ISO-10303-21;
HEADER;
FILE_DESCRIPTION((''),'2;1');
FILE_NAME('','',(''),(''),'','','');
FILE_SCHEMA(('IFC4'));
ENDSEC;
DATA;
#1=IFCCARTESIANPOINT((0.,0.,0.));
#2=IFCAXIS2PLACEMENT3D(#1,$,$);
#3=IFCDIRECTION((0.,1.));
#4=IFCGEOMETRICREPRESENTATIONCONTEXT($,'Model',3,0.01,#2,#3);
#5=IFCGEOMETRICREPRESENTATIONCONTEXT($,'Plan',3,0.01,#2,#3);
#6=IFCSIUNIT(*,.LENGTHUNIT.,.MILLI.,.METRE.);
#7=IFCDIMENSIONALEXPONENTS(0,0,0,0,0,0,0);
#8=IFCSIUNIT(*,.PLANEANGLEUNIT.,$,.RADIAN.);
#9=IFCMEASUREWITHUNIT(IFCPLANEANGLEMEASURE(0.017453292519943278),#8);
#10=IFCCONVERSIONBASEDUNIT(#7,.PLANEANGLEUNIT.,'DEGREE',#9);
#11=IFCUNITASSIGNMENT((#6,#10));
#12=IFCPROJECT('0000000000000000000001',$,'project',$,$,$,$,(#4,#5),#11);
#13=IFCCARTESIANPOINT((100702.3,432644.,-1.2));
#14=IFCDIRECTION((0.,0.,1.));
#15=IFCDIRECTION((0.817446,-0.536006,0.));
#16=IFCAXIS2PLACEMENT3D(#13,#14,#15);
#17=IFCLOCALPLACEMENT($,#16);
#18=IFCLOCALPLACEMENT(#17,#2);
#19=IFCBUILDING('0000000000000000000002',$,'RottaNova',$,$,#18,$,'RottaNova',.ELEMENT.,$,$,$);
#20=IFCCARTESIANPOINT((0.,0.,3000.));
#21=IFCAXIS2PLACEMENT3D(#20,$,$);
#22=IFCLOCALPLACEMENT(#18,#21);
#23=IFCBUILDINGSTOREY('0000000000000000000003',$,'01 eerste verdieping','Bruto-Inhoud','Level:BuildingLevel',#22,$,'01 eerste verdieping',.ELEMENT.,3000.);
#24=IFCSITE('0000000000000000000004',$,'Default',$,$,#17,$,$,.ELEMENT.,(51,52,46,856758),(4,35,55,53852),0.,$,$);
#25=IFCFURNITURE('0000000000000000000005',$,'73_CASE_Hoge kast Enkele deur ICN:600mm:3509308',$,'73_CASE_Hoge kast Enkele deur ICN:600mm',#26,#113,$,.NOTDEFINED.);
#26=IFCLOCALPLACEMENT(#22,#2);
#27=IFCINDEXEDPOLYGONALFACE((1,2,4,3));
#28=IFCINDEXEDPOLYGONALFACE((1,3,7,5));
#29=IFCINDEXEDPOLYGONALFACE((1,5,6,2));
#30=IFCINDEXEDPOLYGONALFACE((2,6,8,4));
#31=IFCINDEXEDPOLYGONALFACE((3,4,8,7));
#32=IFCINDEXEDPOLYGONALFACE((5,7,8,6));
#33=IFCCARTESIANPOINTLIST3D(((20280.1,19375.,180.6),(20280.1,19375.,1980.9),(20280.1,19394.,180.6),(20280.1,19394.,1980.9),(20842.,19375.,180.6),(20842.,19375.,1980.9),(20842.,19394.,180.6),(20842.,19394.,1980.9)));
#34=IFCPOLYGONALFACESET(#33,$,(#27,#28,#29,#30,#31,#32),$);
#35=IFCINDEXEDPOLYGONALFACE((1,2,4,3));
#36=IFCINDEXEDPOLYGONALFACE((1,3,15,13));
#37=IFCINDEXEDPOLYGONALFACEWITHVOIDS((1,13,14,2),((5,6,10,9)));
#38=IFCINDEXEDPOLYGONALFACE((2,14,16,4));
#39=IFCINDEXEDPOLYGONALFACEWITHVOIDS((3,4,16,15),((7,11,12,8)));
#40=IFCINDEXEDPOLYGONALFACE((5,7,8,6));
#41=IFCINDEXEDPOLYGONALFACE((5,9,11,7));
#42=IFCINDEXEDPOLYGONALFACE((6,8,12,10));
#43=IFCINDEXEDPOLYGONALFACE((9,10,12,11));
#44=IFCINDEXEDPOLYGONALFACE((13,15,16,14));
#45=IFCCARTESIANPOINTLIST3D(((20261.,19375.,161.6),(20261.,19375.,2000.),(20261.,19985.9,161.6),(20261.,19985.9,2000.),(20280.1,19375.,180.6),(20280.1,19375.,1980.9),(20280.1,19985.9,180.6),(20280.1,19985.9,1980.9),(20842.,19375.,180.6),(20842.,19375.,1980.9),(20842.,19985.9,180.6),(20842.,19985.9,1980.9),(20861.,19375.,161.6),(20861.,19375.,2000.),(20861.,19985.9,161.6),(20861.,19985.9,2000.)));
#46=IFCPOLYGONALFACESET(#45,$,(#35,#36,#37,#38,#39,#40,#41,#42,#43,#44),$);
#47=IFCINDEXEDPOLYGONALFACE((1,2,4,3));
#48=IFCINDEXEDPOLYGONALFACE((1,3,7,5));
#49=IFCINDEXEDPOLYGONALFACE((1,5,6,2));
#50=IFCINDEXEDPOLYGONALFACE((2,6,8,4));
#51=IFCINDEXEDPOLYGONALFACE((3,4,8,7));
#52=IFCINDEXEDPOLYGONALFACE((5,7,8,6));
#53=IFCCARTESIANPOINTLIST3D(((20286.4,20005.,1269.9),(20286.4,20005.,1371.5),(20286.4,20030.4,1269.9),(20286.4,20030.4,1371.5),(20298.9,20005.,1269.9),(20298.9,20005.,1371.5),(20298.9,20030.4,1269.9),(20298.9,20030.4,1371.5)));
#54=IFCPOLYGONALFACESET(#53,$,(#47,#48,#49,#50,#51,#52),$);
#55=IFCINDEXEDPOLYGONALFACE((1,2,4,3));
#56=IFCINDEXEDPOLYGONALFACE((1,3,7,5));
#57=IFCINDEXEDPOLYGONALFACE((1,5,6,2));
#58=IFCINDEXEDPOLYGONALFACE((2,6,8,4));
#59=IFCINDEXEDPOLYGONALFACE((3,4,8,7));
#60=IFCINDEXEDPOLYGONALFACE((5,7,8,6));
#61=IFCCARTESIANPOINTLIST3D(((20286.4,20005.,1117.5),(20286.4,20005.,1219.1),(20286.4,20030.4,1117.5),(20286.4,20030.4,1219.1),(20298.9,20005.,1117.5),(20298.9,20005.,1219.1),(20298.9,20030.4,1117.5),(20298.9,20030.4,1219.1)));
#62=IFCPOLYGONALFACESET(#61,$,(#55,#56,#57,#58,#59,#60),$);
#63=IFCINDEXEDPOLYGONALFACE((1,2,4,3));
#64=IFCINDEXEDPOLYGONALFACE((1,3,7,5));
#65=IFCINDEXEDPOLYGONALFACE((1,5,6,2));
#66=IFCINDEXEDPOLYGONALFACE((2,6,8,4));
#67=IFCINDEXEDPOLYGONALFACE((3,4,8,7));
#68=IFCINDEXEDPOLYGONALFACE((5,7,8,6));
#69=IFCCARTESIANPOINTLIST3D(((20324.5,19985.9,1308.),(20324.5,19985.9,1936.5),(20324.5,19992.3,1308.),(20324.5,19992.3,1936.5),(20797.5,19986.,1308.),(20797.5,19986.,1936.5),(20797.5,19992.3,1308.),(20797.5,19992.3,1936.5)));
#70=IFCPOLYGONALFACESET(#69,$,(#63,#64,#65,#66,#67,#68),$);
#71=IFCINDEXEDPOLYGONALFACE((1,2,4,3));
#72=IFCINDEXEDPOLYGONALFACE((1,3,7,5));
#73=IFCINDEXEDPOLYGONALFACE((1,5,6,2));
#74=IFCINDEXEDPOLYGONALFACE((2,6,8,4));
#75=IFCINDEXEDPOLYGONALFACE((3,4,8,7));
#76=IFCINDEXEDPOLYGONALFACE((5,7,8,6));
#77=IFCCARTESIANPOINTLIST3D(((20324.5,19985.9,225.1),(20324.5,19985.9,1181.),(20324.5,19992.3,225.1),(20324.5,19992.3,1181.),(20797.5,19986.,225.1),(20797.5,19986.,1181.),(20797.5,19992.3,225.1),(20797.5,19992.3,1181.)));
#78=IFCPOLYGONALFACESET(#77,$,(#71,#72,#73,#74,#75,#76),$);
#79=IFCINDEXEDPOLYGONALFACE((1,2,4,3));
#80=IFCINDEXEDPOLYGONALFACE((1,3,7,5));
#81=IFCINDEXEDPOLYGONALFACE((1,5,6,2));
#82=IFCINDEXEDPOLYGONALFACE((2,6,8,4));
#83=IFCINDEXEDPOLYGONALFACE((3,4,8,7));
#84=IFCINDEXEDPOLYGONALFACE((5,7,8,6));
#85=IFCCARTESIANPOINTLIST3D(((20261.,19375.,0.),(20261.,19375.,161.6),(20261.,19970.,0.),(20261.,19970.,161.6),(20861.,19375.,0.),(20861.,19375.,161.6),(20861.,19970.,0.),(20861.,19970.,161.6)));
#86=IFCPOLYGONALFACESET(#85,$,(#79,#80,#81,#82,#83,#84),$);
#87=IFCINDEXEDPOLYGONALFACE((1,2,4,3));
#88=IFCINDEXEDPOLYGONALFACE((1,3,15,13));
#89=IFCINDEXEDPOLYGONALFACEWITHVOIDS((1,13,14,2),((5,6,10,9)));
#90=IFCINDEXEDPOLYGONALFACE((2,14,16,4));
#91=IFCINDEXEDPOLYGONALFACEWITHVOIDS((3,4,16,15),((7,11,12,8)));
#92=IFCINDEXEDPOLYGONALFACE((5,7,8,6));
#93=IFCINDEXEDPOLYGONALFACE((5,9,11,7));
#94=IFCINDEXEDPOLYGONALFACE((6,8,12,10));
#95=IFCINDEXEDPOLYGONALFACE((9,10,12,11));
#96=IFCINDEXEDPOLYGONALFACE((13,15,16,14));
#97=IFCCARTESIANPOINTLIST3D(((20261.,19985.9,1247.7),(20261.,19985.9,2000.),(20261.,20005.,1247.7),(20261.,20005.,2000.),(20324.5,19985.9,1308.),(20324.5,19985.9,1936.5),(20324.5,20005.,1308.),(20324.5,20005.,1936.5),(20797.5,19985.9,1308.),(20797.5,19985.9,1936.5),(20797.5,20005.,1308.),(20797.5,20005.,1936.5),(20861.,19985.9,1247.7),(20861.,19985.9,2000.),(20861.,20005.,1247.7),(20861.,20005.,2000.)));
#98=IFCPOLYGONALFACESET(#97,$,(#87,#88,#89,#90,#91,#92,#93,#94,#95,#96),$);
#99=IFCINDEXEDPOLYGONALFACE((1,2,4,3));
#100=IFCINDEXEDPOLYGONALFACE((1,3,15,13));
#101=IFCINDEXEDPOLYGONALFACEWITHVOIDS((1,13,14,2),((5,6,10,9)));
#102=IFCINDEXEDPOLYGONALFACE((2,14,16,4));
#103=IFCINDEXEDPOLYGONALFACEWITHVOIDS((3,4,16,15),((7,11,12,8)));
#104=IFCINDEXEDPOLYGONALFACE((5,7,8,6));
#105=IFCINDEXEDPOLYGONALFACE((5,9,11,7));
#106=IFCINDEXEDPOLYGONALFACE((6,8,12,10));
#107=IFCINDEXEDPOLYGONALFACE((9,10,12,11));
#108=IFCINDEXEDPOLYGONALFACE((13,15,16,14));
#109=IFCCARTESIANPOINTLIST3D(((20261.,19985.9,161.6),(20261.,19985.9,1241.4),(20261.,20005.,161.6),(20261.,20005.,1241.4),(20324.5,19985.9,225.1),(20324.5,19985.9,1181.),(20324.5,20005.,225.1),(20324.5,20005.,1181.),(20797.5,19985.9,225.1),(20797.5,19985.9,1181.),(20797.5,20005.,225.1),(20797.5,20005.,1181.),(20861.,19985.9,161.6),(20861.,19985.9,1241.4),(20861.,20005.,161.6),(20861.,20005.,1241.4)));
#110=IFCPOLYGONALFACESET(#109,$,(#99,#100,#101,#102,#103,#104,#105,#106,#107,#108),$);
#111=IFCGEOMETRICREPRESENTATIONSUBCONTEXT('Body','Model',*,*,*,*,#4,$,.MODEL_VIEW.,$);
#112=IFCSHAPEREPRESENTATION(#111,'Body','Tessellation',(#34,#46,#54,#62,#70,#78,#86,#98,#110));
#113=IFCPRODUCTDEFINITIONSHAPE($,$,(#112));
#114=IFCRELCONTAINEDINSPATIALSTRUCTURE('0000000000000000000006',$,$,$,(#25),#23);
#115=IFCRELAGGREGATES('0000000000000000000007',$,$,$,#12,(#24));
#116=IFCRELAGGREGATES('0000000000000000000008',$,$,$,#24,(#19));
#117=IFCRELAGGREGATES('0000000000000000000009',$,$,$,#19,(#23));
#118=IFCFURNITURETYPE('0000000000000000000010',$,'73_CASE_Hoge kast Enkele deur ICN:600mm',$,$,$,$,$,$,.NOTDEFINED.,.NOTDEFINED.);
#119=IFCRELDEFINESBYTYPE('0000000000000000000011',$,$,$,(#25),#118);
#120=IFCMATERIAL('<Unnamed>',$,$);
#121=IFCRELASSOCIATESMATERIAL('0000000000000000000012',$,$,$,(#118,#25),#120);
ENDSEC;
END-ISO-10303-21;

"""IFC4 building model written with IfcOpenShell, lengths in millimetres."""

from ifc_helpers import new_model, entity, si_unit, converted_unit, direction, frame, origin, place, context, subcontext, project, spatial, indexed_curve, outline, extrude, source, transform, mapped, material, type_object, type_shapes, element, save


model = new_model("IFC4")

# Units and contexts
model_context = context("Model", 3, precision=0.01, world=origin(), true_north=direction((0.0, 1.0)))
plan_context = context("Plan", 3, precision=0.01, world=origin(), true_north=direction((0.0, 1.0)))
body_context = subcontext(model_context, "Body", "Model", "MODEL_VIEW")
ifc_project = project(units=[si_unit("LENGTHUNIT", "METRE", prefix="MILLI"), converted_unit("PLANEANGLEUNIT", "DEGREE", entity("IfcPlaneAngleMeasure", 0.017453292519943278), si_unit("PLANEANGLEUNIT", "RADIAN"), dimensions=[0, 0, 0, 0, 0, 0, 0])], contexts=[model_context, plan_context])

# Site, building, storey
site_placement = place(None, frame((100702.3, 432644.0, -1.2), z_axis=(0.0, 0.0, 1.0), x_axis=(0.817446, -0.536006, 0.0)))
site = spatial("IfcSite", under=ifc_project, at=site_placement, Name="Default", CompositionType="ELEMENT", RefLatitude=(51, 52, 46, 856758), RefLongitude=(4, 35, 55, 53852), RefElevation=0.0)
building_placement = place(site_placement, origin())
building = spatial("IfcBuilding", under=site, at=building_placement, Name="RottaNova", LongName="RottaNova", CompositionType="ELEMENT")
storey_placement = place(building_placement, frame((0.0, 0.0, 3000.0)))
storey = spatial("IfcBuildingStorey", under=building, at=storey_placement, Name="01 eerste verdieping", Description="Bruto-Inhoud", ObjectType="Level:BuildingLevel", LongName="01 eerste verdieping", CompositionType="ELEMENT", Elevation=3000.0)

# Furniture
ifc_material_1 = material(Name="<Unnamed>")
furniture_type = type_object("IfcFurnitureType", Name="73_CASE_Hoge kast Enkele deur ICN:600mm", AssemblyPlace="NOTDEFINED", PredefinedType="NOTDEFINED", material=ifc_material_1)
shared_shape_1 = source(origin(), body_context, "Body", "SweptSolid", [
    extrude(outline(indexed_curve([(-9.5, -280.9), (9.5, -280.9), (9.5, 280.9), (-9.5, 280.9), (-9.5, -280.9)], self_intersect=False)), frame((18.7, -9.5, 180.6), z_axis=(0.0, 0.0, 1.0), x_axis=(0.0, 1.0, 0.0)), (0.0, 0.0, 1.0), 1800.3),
    extrude(outline(indexed_curve([(-300.0, -919.2), (300.0, -919.2), (300.0, 919.2), (-300.0, 919.2), (-300.0, -919.2)], self_intersect=False), holes=[indexed_curve([(-280.9, 900.2), (281.0, 900.2), (281.0, -900.2), (-280.9, -900.2), (-280.9, 900.2)], self_intersect=False)]), frame((18.7, -610.9, 1080.8), z_axis=(0.0, 1.0, 0.0), x_axis=(-1.0, 0.0, 0.0)), (0.0, 0.0, 1.0), 610.9),
    extrude(outline(indexed_curve([(-12.7, -6.3), (12.7, -6.3), (12.7, 6.3), (-12.7, 6.3), (-12.7, -6.3)], self_intersect=False)), frame((287.1, -642.7, 1269.9), z_axis=(0.0, 0.0, 1.0), x_axis=(0.0, 1.0, 0.0)), (0.0, 0.0, 1.0), 101.6),
    extrude(outline(indexed_curve([(-12.7, -6.3), (12.7, -6.3), (12.7, 6.3), (-12.7, 6.3), (-12.7, -6.3)], self_intersect=False)), frame((287.1, -642.7, 1117.5), z_axis=(0.0, 0.0, 1.0), x_axis=(0.0, 1.0, 0.0)), (0.0, 0.0, 1.0), 101.6),
    extrude(outline(indexed_curve([(-3.2, -236.5), (3.2, -236.5), (3.2, 236.5), (-3.2, 236.5), (-3.2, -236.5)], self_intersect=False)), frame((18.7, -614.1, 1308.0), z_axis=(0.0, 0.0, 1.0), x_axis=(0.0, 1.0, 0.0)), (0.0, 0.0, 1.0), 628.5),
    extrude(outline(indexed_curve([(-3.2, -236.5), (3.2, -236.5), (3.2, 236.5), (-3.2, 236.5), (-3.2, -236.5)], self_intersect=False)), frame((18.7, -614.1, 225.1), z_axis=(0.0, 0.0, 1.0), x_axis=(0.0, 1.0, 0.0)), (0.0, 0.0, 1.0), 956.0),
    extrude(outline(indexed_curve([(-300.0, -297.5), (300.0, -297.5), (300.0, 297.5), (-300.0, 297.5), (-300.0, -297.5)], self_intersect=False)), frame((18.7, -297.5, 0.0), z_axis=(0.0, 0.0, 1.0), x_axis=(-1.0, 0.0, 0.0)), (0.0, 0.0, 1.0), 161.6),
    extrude(outline(indexed_curve([(-376.1, -300.0), (376.1, -300.0), (376.1, 300.0), (-376.1, 300.0), (-376.1, -300.0)], self_intersect=False), holes=[indexed_curve([(-312.6, -236.5), (-312.6, 236.5), (315.8, 236.5), (315.8, -236.5), (-312.6, -236.5)], self_intersect=False)]), frame((18.7, -630.0, 1623.9), z_axis=(0.0, 1.0, 0.0), x_axis=(0.0, 0.0, -1.0)), (0.0, 0.0, 1.0), 19.1),
    extrude(outline(indexed_curve([(-300.0, -539.9), (300.0, -539.9), (300.0, 539.9), (-300.0, 539.9), (-300.0, -539.9)], self_intersect=False), holes=[indexed_curve([(-236.5, 479.6), (236.5, 479.6), (236.5, -476.4), (-236.5, -476.4), (-236.5, 479.6)], self_intersect=False)]), frame((18.7, -630.0, 701.5), z_axis=(0.0, 1.0, 0.0), x_axis=(-1.0, 0.0, 0.0)), (0.0, 0.0, 1.0), 19.1),
])
type_shapes(furniture_type, [shared_shape_1])
for number, where, z_axis, x_axis, name in (
    (1, (20579.7, 19375.0, 0.0), (0.0, 0.0, 1.0), (-1.0, 0.0, 0.0), "73_CASE_Hoge kast Enkele deur ICN:600mm:3509308"),
):
    element("IfcFurniture", number, at=place(storey_placement, frame(where, z_axis=z_axis, x_axis=x_axis)), inside=storey, type_object=furniture_type, material=ifc_material_1, Name=name, ObjectType="73_CASE_Hoge kast Enkele deur ICN:600mm", PredefinedType="NOTDEFINED", context=body_context, shape_type="MappedRepresentation", body=[
        mapped(shared_shape_1, transform((0.0, 0.0, 0.0), scale=1.0)),
    ])

save(model, "model.ifc")
